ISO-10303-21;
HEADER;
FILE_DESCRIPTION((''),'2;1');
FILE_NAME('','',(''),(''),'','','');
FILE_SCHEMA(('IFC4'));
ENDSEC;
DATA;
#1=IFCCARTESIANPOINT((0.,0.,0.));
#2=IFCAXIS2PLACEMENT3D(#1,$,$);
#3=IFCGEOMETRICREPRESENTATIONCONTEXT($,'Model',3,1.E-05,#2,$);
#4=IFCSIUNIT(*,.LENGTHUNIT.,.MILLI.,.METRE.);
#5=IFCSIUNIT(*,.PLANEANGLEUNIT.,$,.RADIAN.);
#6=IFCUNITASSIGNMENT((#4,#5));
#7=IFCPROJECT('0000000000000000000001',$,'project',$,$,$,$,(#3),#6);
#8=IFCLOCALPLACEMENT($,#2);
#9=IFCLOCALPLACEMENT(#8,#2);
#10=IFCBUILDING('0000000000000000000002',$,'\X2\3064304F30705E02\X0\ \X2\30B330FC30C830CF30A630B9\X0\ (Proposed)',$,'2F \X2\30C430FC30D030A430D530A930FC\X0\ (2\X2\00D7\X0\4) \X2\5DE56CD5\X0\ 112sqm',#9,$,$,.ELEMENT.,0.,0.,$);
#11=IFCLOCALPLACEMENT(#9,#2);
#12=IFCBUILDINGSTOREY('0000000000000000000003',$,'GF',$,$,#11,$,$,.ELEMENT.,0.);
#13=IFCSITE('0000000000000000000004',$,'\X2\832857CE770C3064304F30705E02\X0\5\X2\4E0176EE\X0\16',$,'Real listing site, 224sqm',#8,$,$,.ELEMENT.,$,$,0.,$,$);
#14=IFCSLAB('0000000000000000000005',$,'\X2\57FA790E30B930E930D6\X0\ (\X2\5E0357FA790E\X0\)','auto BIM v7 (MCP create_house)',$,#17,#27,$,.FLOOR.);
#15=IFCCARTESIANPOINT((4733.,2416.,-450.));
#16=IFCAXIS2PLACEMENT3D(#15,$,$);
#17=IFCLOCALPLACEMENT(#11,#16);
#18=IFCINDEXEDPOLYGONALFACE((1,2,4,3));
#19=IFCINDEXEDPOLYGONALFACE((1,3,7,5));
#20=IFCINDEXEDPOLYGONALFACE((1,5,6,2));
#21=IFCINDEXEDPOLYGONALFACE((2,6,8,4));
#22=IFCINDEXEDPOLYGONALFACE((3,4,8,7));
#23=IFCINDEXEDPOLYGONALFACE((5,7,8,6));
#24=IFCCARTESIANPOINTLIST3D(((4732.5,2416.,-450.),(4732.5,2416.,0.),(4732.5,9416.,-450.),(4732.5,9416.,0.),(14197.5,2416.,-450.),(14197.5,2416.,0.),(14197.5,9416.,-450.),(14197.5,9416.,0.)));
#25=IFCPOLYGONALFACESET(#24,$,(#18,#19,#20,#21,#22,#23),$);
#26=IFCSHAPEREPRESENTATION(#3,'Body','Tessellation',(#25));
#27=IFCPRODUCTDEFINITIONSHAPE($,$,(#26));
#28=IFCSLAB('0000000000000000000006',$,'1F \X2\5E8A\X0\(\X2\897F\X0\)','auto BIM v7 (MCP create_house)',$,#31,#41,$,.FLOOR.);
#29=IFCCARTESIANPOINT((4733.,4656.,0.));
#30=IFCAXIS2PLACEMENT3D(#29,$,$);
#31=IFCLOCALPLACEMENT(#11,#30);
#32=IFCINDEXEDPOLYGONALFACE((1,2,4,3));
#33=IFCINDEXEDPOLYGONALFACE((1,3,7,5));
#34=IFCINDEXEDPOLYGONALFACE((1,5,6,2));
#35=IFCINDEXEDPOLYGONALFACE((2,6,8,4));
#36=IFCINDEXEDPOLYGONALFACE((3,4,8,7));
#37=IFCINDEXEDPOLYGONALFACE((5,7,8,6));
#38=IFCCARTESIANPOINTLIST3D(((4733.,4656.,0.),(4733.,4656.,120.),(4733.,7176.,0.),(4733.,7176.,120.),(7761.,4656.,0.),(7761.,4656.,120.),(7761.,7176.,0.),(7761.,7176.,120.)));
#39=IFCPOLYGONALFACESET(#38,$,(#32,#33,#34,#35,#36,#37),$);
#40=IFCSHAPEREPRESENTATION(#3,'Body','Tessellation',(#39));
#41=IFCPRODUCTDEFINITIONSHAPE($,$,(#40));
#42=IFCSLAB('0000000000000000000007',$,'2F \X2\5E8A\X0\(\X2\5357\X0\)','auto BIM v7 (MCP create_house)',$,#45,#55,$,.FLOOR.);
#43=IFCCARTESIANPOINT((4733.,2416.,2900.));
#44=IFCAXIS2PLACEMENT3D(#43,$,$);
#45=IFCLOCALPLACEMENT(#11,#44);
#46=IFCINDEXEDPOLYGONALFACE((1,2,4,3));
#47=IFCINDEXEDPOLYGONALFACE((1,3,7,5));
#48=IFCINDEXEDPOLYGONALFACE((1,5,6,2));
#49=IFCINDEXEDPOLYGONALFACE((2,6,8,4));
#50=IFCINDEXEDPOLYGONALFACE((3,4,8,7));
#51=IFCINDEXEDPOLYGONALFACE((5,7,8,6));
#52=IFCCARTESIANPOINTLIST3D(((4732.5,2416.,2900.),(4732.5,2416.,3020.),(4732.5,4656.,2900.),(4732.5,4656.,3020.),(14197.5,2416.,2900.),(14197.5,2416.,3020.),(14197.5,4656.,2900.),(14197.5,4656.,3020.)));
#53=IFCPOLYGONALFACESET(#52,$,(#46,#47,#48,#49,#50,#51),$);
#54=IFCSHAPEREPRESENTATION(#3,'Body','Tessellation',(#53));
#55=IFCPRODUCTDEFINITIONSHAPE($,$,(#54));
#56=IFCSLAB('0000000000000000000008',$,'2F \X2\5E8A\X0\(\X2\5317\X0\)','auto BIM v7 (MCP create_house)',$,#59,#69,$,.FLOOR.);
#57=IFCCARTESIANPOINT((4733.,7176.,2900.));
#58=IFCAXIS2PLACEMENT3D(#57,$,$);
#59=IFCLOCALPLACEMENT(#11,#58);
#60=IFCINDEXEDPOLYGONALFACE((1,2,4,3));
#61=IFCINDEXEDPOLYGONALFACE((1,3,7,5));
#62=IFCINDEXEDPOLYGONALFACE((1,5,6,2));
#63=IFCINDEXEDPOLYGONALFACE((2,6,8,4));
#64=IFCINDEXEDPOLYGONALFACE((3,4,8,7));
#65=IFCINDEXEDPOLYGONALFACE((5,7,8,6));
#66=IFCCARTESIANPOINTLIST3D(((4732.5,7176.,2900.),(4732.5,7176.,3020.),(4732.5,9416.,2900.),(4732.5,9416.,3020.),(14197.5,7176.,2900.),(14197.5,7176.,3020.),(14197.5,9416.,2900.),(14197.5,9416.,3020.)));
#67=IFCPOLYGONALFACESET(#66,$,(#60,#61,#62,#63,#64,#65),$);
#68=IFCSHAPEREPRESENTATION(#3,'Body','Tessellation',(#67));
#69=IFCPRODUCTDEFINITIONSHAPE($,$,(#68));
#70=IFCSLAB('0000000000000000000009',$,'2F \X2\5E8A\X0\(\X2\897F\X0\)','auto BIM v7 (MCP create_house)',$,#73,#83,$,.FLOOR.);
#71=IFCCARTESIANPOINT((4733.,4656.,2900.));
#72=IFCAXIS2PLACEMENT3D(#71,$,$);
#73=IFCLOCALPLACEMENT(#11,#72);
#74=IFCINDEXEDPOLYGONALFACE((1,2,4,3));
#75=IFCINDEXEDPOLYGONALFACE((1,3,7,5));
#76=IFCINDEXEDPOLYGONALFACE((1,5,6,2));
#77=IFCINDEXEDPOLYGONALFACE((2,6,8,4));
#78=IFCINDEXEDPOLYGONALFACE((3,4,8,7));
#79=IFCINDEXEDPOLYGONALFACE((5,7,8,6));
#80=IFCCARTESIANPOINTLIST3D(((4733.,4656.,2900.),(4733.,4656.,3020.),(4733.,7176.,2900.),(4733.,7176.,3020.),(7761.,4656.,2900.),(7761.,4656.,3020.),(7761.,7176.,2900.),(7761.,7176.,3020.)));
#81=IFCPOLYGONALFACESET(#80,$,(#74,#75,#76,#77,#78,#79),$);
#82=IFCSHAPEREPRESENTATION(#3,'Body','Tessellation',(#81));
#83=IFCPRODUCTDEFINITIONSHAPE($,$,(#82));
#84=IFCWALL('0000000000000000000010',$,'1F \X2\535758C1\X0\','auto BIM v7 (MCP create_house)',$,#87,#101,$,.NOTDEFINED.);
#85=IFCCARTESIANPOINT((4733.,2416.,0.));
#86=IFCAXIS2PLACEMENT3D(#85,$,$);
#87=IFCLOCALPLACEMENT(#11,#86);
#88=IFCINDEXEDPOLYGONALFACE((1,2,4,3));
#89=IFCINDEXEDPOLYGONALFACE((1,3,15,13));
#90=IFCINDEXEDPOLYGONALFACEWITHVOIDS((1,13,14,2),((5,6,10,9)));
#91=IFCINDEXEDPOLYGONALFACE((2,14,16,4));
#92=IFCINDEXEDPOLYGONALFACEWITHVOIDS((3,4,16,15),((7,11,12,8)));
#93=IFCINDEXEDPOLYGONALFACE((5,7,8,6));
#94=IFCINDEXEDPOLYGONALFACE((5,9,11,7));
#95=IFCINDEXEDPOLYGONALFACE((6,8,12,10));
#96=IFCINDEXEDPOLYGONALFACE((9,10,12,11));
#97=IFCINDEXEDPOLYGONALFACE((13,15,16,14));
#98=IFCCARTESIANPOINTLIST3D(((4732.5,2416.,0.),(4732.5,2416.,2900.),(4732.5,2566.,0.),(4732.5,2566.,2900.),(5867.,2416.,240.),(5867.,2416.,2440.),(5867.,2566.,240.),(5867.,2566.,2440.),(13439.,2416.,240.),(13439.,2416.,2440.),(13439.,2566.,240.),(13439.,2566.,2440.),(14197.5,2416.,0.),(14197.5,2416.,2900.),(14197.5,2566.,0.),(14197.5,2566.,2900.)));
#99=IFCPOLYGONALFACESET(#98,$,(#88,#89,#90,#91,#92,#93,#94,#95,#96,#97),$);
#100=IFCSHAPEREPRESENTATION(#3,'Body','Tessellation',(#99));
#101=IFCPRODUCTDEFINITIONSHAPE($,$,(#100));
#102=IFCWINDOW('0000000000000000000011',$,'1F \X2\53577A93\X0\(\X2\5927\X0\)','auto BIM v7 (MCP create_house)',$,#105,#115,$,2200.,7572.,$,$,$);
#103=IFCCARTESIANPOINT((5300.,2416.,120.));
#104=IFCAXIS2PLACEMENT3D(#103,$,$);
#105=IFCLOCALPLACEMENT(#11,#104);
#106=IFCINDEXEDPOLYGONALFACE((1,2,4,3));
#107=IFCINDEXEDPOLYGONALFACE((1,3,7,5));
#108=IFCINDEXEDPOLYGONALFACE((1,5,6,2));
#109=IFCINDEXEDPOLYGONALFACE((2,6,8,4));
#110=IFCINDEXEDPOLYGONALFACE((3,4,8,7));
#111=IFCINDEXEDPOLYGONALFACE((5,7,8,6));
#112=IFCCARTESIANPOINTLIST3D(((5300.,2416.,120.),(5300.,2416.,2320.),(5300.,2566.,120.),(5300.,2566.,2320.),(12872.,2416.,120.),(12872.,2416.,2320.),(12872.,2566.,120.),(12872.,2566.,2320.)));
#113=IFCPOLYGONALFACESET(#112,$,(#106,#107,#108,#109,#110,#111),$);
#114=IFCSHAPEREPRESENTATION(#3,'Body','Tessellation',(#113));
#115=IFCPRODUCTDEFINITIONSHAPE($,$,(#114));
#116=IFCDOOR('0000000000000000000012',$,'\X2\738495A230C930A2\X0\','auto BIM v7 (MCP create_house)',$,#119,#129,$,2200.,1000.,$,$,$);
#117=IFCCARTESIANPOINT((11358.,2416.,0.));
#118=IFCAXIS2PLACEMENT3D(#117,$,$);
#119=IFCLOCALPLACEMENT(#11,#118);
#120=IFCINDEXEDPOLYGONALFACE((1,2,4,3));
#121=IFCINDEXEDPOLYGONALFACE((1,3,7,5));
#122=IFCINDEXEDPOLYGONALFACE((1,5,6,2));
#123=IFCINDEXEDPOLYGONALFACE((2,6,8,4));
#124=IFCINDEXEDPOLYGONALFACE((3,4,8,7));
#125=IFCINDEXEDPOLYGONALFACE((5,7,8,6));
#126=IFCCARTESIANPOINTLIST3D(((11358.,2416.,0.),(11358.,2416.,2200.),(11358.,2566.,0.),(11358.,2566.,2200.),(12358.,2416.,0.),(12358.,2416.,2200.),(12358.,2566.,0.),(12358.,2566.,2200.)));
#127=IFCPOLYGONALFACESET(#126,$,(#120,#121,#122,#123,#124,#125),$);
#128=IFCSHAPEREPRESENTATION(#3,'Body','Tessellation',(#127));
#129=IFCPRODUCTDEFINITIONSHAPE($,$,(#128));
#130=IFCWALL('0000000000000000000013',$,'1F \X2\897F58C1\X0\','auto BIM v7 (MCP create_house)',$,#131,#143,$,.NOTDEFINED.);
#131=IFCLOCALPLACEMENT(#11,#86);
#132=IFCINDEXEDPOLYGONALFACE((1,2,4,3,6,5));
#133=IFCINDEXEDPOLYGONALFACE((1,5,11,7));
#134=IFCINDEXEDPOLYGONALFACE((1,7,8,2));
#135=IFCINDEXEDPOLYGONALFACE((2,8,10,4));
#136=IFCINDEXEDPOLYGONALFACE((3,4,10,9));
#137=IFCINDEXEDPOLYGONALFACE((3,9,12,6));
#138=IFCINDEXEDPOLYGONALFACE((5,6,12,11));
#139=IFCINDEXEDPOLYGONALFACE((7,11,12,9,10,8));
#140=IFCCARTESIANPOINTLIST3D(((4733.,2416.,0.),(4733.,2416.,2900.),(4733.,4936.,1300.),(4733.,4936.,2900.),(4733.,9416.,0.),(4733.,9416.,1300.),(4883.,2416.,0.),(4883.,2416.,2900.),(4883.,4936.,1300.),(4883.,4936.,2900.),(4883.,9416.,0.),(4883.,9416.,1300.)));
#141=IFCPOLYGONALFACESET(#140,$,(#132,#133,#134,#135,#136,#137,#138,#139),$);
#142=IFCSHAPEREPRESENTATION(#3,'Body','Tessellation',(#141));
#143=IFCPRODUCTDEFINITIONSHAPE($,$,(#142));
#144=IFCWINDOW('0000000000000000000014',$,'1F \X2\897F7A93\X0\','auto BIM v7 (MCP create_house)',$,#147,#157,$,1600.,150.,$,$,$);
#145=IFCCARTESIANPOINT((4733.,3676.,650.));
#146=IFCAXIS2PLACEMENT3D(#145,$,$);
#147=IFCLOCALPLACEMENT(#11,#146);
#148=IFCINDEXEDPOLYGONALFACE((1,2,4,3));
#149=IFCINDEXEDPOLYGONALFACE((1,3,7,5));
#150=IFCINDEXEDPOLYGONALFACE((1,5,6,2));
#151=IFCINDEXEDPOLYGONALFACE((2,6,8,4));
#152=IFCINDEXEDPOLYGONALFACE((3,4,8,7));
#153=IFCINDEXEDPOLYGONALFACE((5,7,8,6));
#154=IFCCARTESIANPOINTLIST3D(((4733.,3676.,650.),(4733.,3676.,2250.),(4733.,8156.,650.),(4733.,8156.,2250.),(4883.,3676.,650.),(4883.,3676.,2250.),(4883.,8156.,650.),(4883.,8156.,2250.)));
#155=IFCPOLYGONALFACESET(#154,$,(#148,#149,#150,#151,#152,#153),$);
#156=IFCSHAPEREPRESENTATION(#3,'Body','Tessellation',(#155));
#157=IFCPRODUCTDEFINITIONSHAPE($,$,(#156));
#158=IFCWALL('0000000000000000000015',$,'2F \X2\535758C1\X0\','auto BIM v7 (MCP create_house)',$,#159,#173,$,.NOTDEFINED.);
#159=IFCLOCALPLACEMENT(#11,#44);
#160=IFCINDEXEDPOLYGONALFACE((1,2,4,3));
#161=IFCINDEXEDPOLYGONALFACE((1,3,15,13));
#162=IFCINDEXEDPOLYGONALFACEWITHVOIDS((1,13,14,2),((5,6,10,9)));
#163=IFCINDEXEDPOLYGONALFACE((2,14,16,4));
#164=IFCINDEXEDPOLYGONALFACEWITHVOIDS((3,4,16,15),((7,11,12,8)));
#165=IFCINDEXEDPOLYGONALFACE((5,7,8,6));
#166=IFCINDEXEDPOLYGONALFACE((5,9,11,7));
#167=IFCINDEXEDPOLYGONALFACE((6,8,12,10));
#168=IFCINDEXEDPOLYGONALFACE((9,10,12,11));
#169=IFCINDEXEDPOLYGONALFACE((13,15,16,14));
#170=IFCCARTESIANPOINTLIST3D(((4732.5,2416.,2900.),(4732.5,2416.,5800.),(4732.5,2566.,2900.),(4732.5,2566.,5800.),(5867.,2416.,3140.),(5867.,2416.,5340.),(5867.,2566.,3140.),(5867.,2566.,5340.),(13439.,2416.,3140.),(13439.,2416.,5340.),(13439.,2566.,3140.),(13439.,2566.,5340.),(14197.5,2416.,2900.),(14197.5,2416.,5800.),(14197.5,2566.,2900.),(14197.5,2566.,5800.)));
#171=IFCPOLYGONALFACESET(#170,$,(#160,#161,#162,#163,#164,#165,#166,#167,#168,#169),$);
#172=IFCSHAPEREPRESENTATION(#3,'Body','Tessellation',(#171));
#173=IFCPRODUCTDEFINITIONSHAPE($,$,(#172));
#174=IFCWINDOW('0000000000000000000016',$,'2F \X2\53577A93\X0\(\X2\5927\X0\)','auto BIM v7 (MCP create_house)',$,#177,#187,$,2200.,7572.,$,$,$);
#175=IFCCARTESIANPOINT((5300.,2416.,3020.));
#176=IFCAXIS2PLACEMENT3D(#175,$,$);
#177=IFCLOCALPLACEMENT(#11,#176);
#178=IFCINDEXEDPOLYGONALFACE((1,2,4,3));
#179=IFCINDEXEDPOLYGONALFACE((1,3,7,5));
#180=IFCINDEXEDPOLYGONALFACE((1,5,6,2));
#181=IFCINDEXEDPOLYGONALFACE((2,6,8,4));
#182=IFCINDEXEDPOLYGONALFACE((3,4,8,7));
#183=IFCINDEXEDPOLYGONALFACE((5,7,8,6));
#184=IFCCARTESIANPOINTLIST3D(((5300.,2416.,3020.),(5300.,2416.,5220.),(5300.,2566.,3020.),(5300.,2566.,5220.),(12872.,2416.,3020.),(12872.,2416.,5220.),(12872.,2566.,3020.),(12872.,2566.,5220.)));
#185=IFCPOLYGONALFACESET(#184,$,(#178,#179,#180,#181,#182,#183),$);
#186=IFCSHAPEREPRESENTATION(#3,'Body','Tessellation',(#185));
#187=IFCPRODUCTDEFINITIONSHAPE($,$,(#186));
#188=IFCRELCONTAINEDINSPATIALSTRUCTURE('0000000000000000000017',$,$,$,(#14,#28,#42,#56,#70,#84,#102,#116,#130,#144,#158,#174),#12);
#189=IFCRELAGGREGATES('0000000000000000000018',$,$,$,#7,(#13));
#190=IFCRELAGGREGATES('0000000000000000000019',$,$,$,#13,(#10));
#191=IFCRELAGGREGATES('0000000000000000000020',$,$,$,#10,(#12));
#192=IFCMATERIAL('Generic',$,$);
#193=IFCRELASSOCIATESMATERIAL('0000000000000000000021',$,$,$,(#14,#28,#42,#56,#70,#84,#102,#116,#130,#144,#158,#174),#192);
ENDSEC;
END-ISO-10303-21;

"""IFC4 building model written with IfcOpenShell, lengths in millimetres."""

from ifc_helpers import new_model, si_unit, frame, frame_2d, origin, place, context, project, spatial, rectangle, extrude, material, element, fill, save


model = new_model("IFC4")

# Units and contexts
model_context = context("Model", 3, precision=1e-05, world=origin())
ifc_project = project(units=[si_unit("LENGTHUNIT", "METRE", prefix="MILLI"), si_unit("PLANEANGLEUNIT", "RADIAN")], contexts=[model_context])

# Site, building, storey
site_placement = place(None, origin())
site = spatial("IfcSite", under=ifc_project, at=site_placement, Name="茨城県つくば市5丁目16", ObjectType="Real listing site, 224sqm", CompositionType="ELEMENT", RefElevation=0.0)
building_placement = place(site_placement, origin())
building = spatial("IfcBuilding", under=site, at=building_placement, Name="つくば市 コートハウス (Proposed)", ObjectType="2F ツーバイフォー (2×4) 工法 112sqm", CompositionType="ELEMENT", ElevationOfRefHeight=0.0, ElevationOfTerrain=0.0)
storey_placement = place(building_placement, origin())
storey = spatial("IfcBuildingStorey", under=building, at=storey_placement, Name="GF", CompositionType="ELEMENT", Elevation=0.0)

# Slabs
ifc_material = material(Name="Generic")
slab_1_placement = place(storey_placement, frame((4733.0, 2416.0, -450.0)))
element("IfcSlab", 1, at=slab_1_placement, inside=storey, material=ifc_material, Name="基礎スラブ (布基礎)", Description="auto BIM v7 (MCP create_house)", PredefinedType="FLOOR", context=model_context, shape_type="SweptSolid", body=[
    extrude(rectangle(XDim=9465.0, YDim=7000.0, at=frame_2d((4732.0, 3500.0))), frame((4733.0, 2416.0, -450.0)), (0.0, 0.0, 1.0), 450.0),
])
slab_2_placement = place(storey_placement, frame((4733.0, 4656.0, 0.0)))
element("IfcSlab", 2, at=slab_2_placement, inside=storey, material=ifc_material, Name="1F 床(西)", Description="auto BIM v7 (MCP create_house)", PredefinedType="FLOOR", context=model_context, shape_type="SweptSolid", body=[
    extrude(rectangle(XDim=3028.0, YDim=2520.0, at=frame_2d((1514.0, 1260.0))), frame((4733.0, 4656.0, 0.0)), (0.0, 0.0, 1.0), 120.0),
])
slab_3_placement = place(storey_placement, frame((4733.0, 2416.0, 2900.0)))
element("IfcSlab", 3, at=slab_3_placement, inside=storey, material=ifc_material, Name="2F 床(南)", Description="auto BIM v7 (MCP create_house)", PredefinedType="FLOOR", context=model_context, shape_type="SweptSolid", body=[
    extrude(rectangle(XDim=9465.0, YDim=2240.0, at=frame_2d((4732.0, 1120.0))), frame((4733.0, 2416.0, 2900.0)), (0.0, 0.0, 1.0), 120.0),
])
slab_4_placement = place(storey_placement, frame((4733.0, 7176.0, 2900.0)))
element("IfcSlab", 4, at=slab_4_placement, inside=storey, material=ifc_material, Name="2F 床(北)", Description="auto BIM v7 (MCP create_house)", PredefinedType="FLOOR", context=model_context, shape_type="SweptSolid", body=[
    extrude(rectangle(XDim=9465.0, YDim=2240.0, at=frame_2d((4732.0, 1120.0))), frame((4733.0, 7176.0, 2900.0)), (0.0, 0.0, 1.0), 120.0),
])
slab_5_placement = place(storey_placement, frame((4733.0, 4656.0, 2900.0)))
element("IfcSlab", 5, at=slab_5_placement, inside=storey, material=ifc_material, Name="2F 床(西)", Description="auto BIM v7 (MCP create_house)", PredefinedType="FLOOR", context=model_context, shape_type="SweptSolid", body=[
    extrude(rectangle(XDim=3028.0, YDim=2520.0, at=frame_2d((1514.0, 1260.0))), frame((4733.0, 4656.0, 2900.0)), (0.0, 0.0, 1.0), 120.0),
])

# Wall, openings, window, door
wall_1_placement = place(storey_placement, frame((4733.0, 2416.0, 0.0)))
wall_1 = element("IfcWall", 6, at=wall_1_placement, inside=storey, material=ifc_material, Name="1F 南壁", Description="auto BIM v7 (MCP create_house)", PredefinedType="NOTDEFINED", context=model_context, shape_type="SweptSolid", body=[
    extrude(rectangle(XDim=9465.0, YDim=150.0, at=frame_2d((4732.0, 75.0))), frame((4733.0, 2416.0, 0.0)), (0.0, 0.0, 1.0), 2900.0),
])
opening_1_placement = place(storey_placement, frame((5300.0, 2416.0, 120.0)))
opening_1 = element("IfcOpeningElement", 7, at=opening_1_placement, cuts=wall_1, PredefinedType="NOTDEFINED", context=model_context, shape_type="SweptSolid", body=[
    extrude(rectangle(XDim=7572.0, YDim=150.0, at=frame_2d((3786.0, 75.0))), frame((5300.0, 2416.0, 120.0)), (0.0, 0.0, 1.0), 2200.0),
])
opening_2_placement = place(storey_placement, frame((11358.0, 2416.0, 0.0)))
opening_2 = element("IfcOpeningElement", 8, at=opening_2_placement, cuts=wall_1, PredefinedType="NOTDEFINED", context=model_context, shape_type="SweptSolid", body=[
    extrude(rectangle(XDim=1000.0, YDim=150.0, at=frame_2d((500.0, 75.0))), frame((11358.0, 2416.0, 0.0)), (0.0, 0.0, 1.0), 2200.0),
])
window_1_placement = place(storey_placement, frame((5300.0, 2416.0, 120.0)))
window_1 = element("IfcWindow", 9, at=window_1_placement, inside=storey, material=ifc_material, Name="1F 南窓(大)", Description="auto BIM v7 (MCP create_house)", OverallHeight=2200.0, OverallWidth=7572.0, context=model_context, shape_type="SweptSolid", body=[
    extrude(rectangle(XDim=7572.0, YDim=150.0, at=frame_2d((3786.0, 75.0))), frame((5300.0, 2416.0, 120.0)), (0.0, 0.0, 1.0), 2200.0),
])
fill(opening_1, window_1)
door_placement = place(storey_placement, frame((11358.0, 2416.0, 0.0)))
door = element("IfcDoor", 10, at=door_placement, inside=storey, material=ifc_material, Name="玄関ドア", Description="auto BIM v7 (MCP create_house)", OverallHeight=2200.0, OverallWidth=1000.0, context=model_context, shape_type="SweptSolid", body=[
    extrude(rectangle(XDim=1000.0, YDim=150.0, at=frame_2d((500.0, 75.0))), frame((11358.0, 2416.0, 0.0)), (0.0, 0.0, 1.0), 2200.0),
])
fill(opening_2, door)

# Walls, openings, windows
wall_2_placement = place(storey_placement, frame((4733.0, 2416.0, 0.0)))
wall_2 = element("IfcWall", 11, at=wall_2_placement, inside=storey, material=ifc_material, Name="1F 西壁", Description="auto BIM v7 (MCP create_house)", PredefinedType="NOTDEFINED", context=model_context, shape_type="SweptSolid", body=[
    extrude(rectangle(XDim=150.0, YDim=7000.0, at=frame_2d((75.0, 3500.0))), frame((4733.0, 2416.0, 0.0)), (0.0, 0.0, 1.0), 2900.0),
])
opening_3_placement = place(storey_placement, frame((4733.0, 3676.0, 650.0)))
opening_3 = element("IfcOpeningElement", 12, at=opening_3_placement, cuts=wall_2, PredefinedType="NOTDEFINED", context=model_context, shape_type="SweptSolid", body=[
    extrude(rectangle(XDim=150.0, YDim=4480.0, at=frame_2d((75.0, 2240.0))), frame((4733.0, 3676.0, 650.0)), (0.0, 0.0, 1.0), 1600.0),
])
window_2_placement = place(storey_placement, frame((4733.0, 3676.0, 650.0)))
window_2 = element("IfcWindow", 13, at=window_2_placement, inside=storey, material=ifc_material, Name="1F 西窓", Description="auto BIM v7 (MCP create_house)", OverallHeight=1600.0, OverallWidth=150.0, context=model_context, shape_type="SweptSolid", body=[
    extrude(rectangle(XDim=150.0, YDim=4480.0, at=frame_2d((75.0, 2240.0))), frame((4733.0, 3676.0, 650.0)), (0.0, 0.0, 1.0), 1600.0),
])
fill(opening_3, window_2)
wall_3_placement = place(storey_placement, frame((4733.0, 2416.0, 2900.0)))
wall_3 = element("IfcWall", 14, at=wall_3_placement, inside=storey, material=ifc_material, Name="2F 南壁", Description="auto BIM v7 (MCP create_house)", PredefinedType="NOTDEFINED", context=model_context, shape_type="SweptSolid", body=[
    extrude(rectangle(XDim=9465.0, YDim=150.0, at=frame_2d((4732.0, 75.0))), frame((4733.0, 2416.0, 2900.0)), (0.0, 0.0, 1.0), 2900.0),
])
opening_4_placement = place(storey_placement, frame((5300.0, 2416.0, 3020.0)))
opening_4 = element("IfcOpeningElement", 15, at=opening_4_placement, cuts=wall_3, PredefinedType="NOTDEFINED", context=model_context, shape_type="SweptSolid", body=[
    extrude(rectangle(XDim=7572.0, YDim=150.0, at=frame_2d((3786.0, 75.0))), frame((5300.0, 2416.0, 3020.0)), (0.0, 0.0, 1.0), 2200.0),
])
window_3_placement = place(storey_placement, frame((5300.0, 2416.0, 3020.0)))
window_3 = element("IfcWindow", 16, at=window_3_placement, inside=storey, material=ifc_material, Name="2F 南窓(大)", Description="auto BIM v7 (MCP create_house)", OverallHeight=2200.0, OverallWidth=7572.0, context=model_context, shape_type="SweptSolid", body=[
    extrude(rectangle(XDim=7572.0, YDim=150.0, at=frame_2d((3786.0, 75.0))), frame((5300.0, 2416.0, 3020.0)), (0.0, 0.0, 1.0), 2200.0),
])
fill(opening_4, window_3)

save(model, "model.ifc")
